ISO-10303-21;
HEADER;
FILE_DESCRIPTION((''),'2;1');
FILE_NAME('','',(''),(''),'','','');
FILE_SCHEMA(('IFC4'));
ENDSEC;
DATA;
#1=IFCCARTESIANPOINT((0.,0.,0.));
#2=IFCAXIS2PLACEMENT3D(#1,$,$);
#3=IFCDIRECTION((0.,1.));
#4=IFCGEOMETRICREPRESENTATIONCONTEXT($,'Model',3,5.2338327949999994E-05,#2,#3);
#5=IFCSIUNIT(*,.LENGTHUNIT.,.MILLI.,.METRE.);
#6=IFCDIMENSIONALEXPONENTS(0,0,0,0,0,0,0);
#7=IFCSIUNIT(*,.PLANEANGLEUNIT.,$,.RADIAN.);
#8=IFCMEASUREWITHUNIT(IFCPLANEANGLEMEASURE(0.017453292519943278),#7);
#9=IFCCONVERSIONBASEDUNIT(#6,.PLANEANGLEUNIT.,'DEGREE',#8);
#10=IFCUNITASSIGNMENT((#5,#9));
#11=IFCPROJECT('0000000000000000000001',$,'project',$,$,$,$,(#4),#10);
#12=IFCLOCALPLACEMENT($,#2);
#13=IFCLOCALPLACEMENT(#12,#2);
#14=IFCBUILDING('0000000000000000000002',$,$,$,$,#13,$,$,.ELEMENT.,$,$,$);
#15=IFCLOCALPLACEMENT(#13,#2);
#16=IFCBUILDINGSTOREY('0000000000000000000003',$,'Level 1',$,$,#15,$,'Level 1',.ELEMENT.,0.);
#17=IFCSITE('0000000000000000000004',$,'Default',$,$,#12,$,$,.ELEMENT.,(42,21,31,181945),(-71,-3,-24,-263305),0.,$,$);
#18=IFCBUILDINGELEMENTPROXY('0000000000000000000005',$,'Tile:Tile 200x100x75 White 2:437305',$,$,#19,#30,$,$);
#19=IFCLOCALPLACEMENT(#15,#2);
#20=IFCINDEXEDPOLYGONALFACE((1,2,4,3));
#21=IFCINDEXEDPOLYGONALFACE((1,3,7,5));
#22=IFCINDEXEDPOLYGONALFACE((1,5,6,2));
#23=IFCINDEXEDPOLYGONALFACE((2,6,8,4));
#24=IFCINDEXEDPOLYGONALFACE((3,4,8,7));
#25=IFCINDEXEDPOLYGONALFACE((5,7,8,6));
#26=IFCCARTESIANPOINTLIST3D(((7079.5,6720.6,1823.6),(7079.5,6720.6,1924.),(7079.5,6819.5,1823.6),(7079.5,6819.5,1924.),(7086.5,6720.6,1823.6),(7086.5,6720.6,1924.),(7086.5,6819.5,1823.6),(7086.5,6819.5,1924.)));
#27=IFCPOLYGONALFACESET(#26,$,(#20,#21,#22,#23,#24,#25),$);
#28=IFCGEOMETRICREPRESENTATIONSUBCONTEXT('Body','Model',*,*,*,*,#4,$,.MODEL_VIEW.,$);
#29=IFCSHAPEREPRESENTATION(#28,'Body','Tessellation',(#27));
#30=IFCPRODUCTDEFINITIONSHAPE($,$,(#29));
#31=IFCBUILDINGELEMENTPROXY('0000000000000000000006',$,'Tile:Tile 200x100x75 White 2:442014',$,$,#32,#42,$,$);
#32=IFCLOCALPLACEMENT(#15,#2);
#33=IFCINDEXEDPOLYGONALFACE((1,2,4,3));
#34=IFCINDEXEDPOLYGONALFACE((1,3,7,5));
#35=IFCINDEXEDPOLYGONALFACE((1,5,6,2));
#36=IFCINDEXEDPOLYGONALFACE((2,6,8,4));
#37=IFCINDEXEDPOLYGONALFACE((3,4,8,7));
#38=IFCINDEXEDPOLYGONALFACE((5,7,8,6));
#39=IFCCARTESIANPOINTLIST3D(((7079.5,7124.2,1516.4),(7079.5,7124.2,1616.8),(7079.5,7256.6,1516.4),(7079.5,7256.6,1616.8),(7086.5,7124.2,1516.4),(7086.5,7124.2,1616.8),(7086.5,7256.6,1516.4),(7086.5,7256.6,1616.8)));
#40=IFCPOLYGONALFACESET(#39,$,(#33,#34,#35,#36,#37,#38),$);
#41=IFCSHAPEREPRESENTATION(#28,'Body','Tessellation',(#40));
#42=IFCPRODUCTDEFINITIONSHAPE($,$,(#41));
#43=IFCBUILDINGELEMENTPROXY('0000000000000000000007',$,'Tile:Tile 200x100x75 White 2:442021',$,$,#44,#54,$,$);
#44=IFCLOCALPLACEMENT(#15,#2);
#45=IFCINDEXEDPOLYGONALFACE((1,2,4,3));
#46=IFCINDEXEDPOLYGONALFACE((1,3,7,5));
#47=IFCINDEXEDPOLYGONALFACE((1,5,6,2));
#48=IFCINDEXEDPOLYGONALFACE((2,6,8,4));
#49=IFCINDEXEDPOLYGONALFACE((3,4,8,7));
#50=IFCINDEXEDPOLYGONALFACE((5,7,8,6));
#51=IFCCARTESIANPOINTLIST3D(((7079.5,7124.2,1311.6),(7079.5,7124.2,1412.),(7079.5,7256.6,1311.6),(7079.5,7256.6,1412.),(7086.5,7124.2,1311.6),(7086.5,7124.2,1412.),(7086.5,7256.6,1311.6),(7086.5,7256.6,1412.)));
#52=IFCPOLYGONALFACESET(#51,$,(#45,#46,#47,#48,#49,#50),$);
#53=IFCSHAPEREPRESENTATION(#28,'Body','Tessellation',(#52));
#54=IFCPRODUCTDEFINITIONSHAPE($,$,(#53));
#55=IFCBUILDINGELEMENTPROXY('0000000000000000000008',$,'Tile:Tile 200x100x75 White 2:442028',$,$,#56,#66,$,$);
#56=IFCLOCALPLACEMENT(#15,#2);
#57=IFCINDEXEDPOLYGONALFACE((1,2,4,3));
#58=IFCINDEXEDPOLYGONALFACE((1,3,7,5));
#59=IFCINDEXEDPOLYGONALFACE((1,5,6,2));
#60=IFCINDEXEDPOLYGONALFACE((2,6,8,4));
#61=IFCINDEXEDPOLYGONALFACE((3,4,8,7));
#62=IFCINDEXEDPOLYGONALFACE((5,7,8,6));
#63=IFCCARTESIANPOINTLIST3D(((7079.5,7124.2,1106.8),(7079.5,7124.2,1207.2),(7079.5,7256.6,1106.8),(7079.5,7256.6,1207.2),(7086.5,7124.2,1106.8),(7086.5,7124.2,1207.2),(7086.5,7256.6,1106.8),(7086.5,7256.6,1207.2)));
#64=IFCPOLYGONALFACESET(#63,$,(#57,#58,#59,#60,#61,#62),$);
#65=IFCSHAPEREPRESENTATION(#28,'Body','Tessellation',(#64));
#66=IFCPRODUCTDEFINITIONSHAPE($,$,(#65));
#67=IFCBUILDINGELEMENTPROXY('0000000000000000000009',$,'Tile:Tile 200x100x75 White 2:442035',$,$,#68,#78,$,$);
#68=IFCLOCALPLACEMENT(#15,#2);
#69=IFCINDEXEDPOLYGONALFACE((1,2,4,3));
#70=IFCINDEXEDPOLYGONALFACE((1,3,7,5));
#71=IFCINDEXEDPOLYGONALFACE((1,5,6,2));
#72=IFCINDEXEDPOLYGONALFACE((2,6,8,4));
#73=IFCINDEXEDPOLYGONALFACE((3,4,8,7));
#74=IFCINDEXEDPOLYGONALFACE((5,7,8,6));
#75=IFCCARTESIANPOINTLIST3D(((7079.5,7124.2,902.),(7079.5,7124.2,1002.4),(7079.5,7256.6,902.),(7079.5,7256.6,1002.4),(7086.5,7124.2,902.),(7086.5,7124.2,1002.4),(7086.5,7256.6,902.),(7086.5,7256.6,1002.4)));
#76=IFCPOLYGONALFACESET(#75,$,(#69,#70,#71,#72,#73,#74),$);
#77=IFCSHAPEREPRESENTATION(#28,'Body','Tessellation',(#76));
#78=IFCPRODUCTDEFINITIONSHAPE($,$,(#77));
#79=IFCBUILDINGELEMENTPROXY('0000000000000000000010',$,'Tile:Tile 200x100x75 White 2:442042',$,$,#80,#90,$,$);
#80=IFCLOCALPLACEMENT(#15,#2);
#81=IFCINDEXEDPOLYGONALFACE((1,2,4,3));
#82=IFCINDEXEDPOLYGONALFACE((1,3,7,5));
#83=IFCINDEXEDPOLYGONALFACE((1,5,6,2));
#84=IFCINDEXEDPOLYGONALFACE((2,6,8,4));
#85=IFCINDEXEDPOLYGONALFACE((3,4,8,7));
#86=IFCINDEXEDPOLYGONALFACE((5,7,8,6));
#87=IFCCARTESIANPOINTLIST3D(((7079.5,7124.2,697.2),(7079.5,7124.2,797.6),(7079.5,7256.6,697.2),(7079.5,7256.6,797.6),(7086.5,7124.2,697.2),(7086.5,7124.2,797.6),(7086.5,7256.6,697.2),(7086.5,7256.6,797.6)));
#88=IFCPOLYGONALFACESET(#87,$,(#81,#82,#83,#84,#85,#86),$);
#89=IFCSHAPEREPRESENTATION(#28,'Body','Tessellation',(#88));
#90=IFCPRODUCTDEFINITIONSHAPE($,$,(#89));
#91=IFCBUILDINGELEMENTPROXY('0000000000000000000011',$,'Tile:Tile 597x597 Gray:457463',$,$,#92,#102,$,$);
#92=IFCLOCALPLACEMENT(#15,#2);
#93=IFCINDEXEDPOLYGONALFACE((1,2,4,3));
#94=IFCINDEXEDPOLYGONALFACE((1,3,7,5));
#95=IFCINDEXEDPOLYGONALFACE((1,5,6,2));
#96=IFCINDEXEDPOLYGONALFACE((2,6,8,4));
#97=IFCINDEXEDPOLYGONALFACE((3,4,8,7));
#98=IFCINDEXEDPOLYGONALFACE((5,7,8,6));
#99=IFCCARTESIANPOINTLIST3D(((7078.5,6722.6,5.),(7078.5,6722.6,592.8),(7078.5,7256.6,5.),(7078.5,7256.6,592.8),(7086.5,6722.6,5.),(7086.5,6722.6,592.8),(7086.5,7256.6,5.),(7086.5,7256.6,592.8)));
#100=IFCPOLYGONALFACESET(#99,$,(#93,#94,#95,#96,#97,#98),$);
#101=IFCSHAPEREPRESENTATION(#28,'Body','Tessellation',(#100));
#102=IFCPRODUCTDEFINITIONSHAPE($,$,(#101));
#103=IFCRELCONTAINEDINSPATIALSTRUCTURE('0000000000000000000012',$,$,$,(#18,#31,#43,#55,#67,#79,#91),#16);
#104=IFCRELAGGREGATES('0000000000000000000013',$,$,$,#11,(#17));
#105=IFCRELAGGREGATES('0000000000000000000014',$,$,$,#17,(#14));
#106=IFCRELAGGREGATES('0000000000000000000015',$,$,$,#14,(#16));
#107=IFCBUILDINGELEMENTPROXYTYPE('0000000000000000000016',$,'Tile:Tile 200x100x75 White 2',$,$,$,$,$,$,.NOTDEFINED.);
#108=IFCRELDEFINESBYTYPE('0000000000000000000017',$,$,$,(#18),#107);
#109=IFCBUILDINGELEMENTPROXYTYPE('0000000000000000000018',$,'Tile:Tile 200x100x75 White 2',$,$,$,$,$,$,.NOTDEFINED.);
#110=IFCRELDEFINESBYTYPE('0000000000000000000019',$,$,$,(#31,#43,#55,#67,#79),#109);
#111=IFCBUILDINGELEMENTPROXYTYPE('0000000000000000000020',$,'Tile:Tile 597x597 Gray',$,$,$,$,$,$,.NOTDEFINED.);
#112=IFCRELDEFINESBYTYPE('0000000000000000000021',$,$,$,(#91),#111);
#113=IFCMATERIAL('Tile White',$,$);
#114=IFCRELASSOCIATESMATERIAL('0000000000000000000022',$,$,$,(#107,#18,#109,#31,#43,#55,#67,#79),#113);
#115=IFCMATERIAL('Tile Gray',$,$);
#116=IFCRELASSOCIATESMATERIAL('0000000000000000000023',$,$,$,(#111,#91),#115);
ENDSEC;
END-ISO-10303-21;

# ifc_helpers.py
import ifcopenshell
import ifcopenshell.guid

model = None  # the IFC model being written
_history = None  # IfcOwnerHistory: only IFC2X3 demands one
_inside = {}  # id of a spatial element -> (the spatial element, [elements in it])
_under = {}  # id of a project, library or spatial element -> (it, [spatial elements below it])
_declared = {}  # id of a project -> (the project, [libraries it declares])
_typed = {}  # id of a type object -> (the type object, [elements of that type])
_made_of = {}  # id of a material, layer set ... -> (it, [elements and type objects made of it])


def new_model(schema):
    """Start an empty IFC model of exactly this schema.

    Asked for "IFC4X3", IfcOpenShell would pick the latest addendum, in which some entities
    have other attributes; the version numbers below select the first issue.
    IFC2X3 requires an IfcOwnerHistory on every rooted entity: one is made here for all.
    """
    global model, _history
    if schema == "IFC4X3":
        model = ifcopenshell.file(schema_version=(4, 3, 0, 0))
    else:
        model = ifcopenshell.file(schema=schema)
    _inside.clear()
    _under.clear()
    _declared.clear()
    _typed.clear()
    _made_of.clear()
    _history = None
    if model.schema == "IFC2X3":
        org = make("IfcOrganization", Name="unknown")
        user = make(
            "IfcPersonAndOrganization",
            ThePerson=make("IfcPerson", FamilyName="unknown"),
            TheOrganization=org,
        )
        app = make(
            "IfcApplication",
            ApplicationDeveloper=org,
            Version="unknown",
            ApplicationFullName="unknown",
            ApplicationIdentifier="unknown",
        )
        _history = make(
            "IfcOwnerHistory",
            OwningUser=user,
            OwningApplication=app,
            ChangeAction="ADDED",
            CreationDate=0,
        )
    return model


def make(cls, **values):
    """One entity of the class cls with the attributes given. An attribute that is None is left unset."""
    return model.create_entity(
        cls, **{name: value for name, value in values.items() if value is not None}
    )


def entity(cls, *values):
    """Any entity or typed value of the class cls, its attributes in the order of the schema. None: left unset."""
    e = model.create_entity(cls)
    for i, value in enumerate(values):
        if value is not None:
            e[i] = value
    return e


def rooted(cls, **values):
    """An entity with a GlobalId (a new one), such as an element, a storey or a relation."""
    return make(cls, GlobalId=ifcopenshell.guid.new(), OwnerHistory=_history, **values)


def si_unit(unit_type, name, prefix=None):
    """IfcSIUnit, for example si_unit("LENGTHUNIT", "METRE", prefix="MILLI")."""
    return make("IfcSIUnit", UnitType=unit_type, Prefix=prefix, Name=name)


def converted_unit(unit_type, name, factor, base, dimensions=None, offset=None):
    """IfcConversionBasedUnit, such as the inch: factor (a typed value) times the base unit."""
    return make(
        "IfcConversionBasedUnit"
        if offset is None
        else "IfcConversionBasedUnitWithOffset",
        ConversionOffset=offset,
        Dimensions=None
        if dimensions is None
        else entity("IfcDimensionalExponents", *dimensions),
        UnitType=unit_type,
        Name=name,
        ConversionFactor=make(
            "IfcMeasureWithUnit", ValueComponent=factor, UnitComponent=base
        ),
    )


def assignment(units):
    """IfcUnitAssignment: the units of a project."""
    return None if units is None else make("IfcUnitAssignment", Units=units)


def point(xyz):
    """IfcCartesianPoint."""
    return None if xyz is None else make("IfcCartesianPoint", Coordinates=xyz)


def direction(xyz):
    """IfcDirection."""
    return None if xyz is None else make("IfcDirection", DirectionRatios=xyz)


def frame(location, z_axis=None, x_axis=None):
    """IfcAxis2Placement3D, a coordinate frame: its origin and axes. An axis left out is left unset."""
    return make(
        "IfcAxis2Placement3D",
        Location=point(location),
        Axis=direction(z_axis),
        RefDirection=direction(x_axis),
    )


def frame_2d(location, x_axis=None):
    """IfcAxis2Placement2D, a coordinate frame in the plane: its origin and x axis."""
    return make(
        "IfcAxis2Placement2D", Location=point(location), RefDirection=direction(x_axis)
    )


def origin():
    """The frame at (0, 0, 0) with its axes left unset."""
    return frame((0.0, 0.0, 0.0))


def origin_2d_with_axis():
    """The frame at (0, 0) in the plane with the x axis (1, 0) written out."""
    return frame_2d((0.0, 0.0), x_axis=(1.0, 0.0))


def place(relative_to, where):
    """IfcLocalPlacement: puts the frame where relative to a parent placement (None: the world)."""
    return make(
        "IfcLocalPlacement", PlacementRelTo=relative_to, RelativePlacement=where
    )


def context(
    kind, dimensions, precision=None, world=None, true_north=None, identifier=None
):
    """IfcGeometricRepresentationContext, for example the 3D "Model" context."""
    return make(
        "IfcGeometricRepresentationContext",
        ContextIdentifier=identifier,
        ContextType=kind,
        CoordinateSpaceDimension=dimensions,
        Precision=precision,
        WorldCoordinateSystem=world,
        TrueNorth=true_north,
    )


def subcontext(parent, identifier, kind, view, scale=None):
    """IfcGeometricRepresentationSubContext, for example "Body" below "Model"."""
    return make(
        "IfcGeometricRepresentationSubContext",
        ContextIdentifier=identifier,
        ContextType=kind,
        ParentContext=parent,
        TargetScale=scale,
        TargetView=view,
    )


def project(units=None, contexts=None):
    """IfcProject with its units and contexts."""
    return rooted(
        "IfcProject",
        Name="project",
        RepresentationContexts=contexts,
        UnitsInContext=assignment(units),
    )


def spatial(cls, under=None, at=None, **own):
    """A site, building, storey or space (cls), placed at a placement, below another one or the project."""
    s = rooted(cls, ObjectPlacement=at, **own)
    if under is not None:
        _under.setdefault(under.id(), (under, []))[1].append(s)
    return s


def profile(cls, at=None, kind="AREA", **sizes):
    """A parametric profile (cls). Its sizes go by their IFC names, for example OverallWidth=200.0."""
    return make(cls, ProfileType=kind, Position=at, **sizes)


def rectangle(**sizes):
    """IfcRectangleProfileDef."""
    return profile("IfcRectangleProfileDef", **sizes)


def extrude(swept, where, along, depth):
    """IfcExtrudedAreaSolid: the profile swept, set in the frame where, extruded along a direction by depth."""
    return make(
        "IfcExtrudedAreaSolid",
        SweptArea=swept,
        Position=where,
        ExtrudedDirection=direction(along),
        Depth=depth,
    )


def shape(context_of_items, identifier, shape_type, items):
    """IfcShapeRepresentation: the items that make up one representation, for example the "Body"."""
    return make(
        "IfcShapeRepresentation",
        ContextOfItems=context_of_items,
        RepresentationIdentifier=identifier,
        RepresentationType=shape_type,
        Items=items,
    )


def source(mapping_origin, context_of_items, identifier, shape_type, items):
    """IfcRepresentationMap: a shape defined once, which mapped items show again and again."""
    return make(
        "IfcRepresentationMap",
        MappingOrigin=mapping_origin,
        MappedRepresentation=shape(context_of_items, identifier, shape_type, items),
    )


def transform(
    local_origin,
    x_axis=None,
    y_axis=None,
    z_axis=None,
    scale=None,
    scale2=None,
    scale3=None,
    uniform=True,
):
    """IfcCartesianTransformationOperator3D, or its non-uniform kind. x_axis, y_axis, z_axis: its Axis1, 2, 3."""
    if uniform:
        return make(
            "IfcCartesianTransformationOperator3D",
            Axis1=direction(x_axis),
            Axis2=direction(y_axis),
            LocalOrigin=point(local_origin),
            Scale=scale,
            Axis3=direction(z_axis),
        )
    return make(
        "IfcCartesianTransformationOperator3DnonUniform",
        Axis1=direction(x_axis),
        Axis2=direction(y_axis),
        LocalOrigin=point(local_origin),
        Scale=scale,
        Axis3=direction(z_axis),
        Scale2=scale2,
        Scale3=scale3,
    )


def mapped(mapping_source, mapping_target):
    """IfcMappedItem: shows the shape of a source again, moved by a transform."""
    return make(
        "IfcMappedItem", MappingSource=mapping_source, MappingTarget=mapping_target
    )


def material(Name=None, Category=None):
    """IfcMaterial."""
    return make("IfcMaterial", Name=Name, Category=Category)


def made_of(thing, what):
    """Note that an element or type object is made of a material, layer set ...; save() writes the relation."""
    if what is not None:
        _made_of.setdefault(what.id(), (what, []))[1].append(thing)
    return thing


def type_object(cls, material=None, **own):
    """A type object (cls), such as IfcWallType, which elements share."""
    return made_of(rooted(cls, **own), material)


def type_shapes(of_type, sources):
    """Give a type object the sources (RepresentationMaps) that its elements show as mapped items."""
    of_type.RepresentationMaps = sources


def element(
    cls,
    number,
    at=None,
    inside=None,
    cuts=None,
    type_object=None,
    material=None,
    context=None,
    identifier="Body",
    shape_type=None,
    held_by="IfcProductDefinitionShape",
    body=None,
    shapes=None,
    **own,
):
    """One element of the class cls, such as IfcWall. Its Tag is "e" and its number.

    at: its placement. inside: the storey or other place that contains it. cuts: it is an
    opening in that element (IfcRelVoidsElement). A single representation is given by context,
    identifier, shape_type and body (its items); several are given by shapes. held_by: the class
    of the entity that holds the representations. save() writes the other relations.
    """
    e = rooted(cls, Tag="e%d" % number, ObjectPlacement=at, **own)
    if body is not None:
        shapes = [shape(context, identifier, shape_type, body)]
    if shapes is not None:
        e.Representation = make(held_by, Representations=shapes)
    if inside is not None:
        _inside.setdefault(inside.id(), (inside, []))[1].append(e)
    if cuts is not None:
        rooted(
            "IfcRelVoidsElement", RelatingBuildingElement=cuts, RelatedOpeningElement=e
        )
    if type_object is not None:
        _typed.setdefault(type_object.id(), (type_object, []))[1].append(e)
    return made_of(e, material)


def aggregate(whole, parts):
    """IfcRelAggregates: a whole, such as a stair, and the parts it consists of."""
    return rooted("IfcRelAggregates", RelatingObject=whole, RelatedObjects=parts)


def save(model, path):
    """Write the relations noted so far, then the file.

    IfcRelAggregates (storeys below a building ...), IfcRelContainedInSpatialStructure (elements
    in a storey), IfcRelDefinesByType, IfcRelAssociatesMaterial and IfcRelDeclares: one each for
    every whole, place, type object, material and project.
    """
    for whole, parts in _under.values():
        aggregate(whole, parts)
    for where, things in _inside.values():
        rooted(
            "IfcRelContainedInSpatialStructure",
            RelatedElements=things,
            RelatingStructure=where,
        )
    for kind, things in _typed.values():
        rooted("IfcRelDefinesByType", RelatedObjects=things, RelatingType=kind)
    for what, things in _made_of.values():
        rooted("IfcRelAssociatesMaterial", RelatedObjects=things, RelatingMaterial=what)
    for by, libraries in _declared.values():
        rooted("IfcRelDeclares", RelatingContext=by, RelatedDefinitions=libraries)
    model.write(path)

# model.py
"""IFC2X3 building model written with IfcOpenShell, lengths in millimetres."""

from ifc_helpers import new_model, entity, si_unit, converted_unit, direction, frame, frame_2d, origin, origin_2d_with_axis, place, context, subcontext, project, spatial, rectangle, extrude, source, transform, mapped, material, type_object, type_shapes, element, save


model = new_model("IFC2X3")

# Units and contexts
model_context = context("Model", 3, precision=5.2338327949999994e-05, world=origin(), true_north=direction((0.0, 1.0)))
body_context = subcontext(model_context, "Body", "Model", "MODEL_VIEW")
ifc_project = project(units=[si_unit("LENGTHUNIT", "METRE", prefix="MILLI"), converted_unit("PLANEANGLEUNIT", "DEGREE", entity("IfcPlaneAngleMeasure", 0.017453292519943278), si_unit("PLANEANGLEUNIT", "RADIAN"), dimensions=[0, 0, 0, 0, 0, 0, 0])], contexts=[model_context])

# Site, building, storey
site_placement = place(None, origin())
site = spatial("IfcSite", under=ifc_project, at=site_placement, Name="Default", CompositionType="ELEMENT", RefLatitude=(42, 21, 31, 181945), RefLongitude=(-71, -3, -24, -263305), RefElevation=0.0)
building_placement = place(site_placement, origin())
building = spatial("IfcBuilding", under=site, at=building_placement, CompositionType="ELEMENT")
storey_placement = place(building_placement, origin())
storey = spatial("IfcBuildingStorey", under=building, at=storey_placement, Name="Level 1", LongName="Level 1", CompositionType="ELEMENT", Elevation=0.0)

# Building element proxies
ifc_material_1 = material(Name="Tile White")
building_element_proxy_type_1 = type_object("IfcBuildingElementProxyType", Name="Tile:Tile 200x100x75 White 2", PredefinedType="NOTDEFINED", material=ifc_material_1)
shared_shape_1 = source(origin(), body_context, "Body", "SweptSolid", [
    extrude(rectangle(XDim=98.9, YDim=100.4, at=origin_2d_with_axis()), frame((-50.2, -49.5, 0.0), z_axis=(0.0, 0.0, 1.0), x_axis=(0.0, -1.0, 0.0)), (0.0, 0.0, 1.0), 7.0),
])
type_shapes(building_element_proxy_type_1, [shared_shape_1])
proxy_1_placement = place(storey_placement, frame((7086.5, 6819.5, 1924.0), z_axis=(-1.0, 0.0, 0.0), x_axis=(0.0, 0.0, 1.0)))
element("IfcBuildingElementProxy", 1, at=proxy_1_placement, inside=storey, type_object=building_element_proxy_type_1, material=ifc_material_1, Name="Tile:Tile 200x100x75 White 2:437305", context=body_context, shape_type="MappedRepresentation", body=[
    mapped(shared_shape_1, transform((0.0, 0.0, 0.0), scale=1.0)),
])
building_element_proxy_type_2 = type_object("IfcBuildingElementProxyType", Name="Tile:Tile 200x100x75 White 2", PredefinedType="NOTDEFINED", material=ifc_material_1)
shared_shape_2 = source(origin(), body_context, "Body", "SweptSolid", [
    extrude(rectangle(XDim=100.4, YDim=132.4, at=frame_2d((0.0, 0.0), x_axis=(1.0, 0.0))), frame((-50.2, 66.2, 0.0)), (0.0, 0.0, 1.0), 7.0),
])
type_shapes(building_element_proxy_type_2, [shared_shape_2])
for number, where, z_axis, x_axis, name in (
    (2, (7086.5, 7124.2, 1616.8), (-1.0, 0.0, 0.0), (0.0, 0.0, 1.0), "Tile:Tile 200x100x75 White 2:442014"),
    (3, (7086.5, 7124.2, 1412.0), (-1.0, 0.0, 0.0), (0.0, 0.0, 1.0), "Tile:Tile 200x100x75 White 2:442021"),
    (4, (7086.5, 7124.2, 1207.2), (-1.0, 0.0, 0.0), (0.0, 0.0, 1.0), "Tile:Tile 200x100x75 White 2:442028"),
    (5, (7086.5, 7124.2, 1002.4), (-1.0, 0.0, 0.0), (0.0, 0.0, 1.0), "Tile:Tile 200x100x75 White 2:442035"),
    (6, (7086.5, 7124.2, 797.6), (-1.0, 0.0, 0.0), (0.0, 0.0, 1.0), "Tile:Tile 200x100x75 White 2:442042"),
):
    element("IfcBuildingElementProxy", number, at=place(storey_placement, frame(where, z_axis=z_axis, x_axis=x_axis)), inside=storey, type_object=building_element_proxy_type_2, material=ifc_material_1, Name=name, context=body_context, shape_type="MappedRepresentation", body=[
        mapped(shared_shape_2, transform((0.0, 0.0, 0.0), scale=1.0)),
    ])
ifc_material_2 = material(Name="Tile Gray")
building_element_proxy_type_3 = type_object("IfcBuildingElementProxyType", Name="Tile:Tile 597x597 Gray", PredefinedType="NOTDEFINED", material=ifc_material_2)
shared_shape_3 = source(origin(), body_context, "Body", "SweptSolid", [
    extrude(rectangle(XDim=534.0, YDim=587.8, at=frame_2d((0.0, 0.0), x_axis=(1.0, 0.0))), frame((-267.0, -293.9, 0.0), z_axis=(0.0, 0.0, 1.0), x_axis=(-1.0, 0.0, 0.0)), (0.0, 0.0, 1.0), 8.0),
])
type_shapes(building_element_proxy_type_3, [shared_shape_3])
proxy_2_placement = place(storey_placement, frame((7086.5, 6722.6, 592.8), z_axis=(-1.0, 0.0, 0.0), x_axis=(0.0, -1.0, 0.0)))
element("IfcBuildingElementProxy", 7, at=proxy_2_placement, inside=storey, type_object=building_element_proxy_type_3, material=ifc_material_2, Name="Tile:Tile 597x597 Gray:457463", context=body_context, shape_type="MappedRepresentation", body=[
    mapped(shared_shape_3, transform((0.0, 0.0, 0.0), scale=1.0)),
])

save(model, "model.ifc")
